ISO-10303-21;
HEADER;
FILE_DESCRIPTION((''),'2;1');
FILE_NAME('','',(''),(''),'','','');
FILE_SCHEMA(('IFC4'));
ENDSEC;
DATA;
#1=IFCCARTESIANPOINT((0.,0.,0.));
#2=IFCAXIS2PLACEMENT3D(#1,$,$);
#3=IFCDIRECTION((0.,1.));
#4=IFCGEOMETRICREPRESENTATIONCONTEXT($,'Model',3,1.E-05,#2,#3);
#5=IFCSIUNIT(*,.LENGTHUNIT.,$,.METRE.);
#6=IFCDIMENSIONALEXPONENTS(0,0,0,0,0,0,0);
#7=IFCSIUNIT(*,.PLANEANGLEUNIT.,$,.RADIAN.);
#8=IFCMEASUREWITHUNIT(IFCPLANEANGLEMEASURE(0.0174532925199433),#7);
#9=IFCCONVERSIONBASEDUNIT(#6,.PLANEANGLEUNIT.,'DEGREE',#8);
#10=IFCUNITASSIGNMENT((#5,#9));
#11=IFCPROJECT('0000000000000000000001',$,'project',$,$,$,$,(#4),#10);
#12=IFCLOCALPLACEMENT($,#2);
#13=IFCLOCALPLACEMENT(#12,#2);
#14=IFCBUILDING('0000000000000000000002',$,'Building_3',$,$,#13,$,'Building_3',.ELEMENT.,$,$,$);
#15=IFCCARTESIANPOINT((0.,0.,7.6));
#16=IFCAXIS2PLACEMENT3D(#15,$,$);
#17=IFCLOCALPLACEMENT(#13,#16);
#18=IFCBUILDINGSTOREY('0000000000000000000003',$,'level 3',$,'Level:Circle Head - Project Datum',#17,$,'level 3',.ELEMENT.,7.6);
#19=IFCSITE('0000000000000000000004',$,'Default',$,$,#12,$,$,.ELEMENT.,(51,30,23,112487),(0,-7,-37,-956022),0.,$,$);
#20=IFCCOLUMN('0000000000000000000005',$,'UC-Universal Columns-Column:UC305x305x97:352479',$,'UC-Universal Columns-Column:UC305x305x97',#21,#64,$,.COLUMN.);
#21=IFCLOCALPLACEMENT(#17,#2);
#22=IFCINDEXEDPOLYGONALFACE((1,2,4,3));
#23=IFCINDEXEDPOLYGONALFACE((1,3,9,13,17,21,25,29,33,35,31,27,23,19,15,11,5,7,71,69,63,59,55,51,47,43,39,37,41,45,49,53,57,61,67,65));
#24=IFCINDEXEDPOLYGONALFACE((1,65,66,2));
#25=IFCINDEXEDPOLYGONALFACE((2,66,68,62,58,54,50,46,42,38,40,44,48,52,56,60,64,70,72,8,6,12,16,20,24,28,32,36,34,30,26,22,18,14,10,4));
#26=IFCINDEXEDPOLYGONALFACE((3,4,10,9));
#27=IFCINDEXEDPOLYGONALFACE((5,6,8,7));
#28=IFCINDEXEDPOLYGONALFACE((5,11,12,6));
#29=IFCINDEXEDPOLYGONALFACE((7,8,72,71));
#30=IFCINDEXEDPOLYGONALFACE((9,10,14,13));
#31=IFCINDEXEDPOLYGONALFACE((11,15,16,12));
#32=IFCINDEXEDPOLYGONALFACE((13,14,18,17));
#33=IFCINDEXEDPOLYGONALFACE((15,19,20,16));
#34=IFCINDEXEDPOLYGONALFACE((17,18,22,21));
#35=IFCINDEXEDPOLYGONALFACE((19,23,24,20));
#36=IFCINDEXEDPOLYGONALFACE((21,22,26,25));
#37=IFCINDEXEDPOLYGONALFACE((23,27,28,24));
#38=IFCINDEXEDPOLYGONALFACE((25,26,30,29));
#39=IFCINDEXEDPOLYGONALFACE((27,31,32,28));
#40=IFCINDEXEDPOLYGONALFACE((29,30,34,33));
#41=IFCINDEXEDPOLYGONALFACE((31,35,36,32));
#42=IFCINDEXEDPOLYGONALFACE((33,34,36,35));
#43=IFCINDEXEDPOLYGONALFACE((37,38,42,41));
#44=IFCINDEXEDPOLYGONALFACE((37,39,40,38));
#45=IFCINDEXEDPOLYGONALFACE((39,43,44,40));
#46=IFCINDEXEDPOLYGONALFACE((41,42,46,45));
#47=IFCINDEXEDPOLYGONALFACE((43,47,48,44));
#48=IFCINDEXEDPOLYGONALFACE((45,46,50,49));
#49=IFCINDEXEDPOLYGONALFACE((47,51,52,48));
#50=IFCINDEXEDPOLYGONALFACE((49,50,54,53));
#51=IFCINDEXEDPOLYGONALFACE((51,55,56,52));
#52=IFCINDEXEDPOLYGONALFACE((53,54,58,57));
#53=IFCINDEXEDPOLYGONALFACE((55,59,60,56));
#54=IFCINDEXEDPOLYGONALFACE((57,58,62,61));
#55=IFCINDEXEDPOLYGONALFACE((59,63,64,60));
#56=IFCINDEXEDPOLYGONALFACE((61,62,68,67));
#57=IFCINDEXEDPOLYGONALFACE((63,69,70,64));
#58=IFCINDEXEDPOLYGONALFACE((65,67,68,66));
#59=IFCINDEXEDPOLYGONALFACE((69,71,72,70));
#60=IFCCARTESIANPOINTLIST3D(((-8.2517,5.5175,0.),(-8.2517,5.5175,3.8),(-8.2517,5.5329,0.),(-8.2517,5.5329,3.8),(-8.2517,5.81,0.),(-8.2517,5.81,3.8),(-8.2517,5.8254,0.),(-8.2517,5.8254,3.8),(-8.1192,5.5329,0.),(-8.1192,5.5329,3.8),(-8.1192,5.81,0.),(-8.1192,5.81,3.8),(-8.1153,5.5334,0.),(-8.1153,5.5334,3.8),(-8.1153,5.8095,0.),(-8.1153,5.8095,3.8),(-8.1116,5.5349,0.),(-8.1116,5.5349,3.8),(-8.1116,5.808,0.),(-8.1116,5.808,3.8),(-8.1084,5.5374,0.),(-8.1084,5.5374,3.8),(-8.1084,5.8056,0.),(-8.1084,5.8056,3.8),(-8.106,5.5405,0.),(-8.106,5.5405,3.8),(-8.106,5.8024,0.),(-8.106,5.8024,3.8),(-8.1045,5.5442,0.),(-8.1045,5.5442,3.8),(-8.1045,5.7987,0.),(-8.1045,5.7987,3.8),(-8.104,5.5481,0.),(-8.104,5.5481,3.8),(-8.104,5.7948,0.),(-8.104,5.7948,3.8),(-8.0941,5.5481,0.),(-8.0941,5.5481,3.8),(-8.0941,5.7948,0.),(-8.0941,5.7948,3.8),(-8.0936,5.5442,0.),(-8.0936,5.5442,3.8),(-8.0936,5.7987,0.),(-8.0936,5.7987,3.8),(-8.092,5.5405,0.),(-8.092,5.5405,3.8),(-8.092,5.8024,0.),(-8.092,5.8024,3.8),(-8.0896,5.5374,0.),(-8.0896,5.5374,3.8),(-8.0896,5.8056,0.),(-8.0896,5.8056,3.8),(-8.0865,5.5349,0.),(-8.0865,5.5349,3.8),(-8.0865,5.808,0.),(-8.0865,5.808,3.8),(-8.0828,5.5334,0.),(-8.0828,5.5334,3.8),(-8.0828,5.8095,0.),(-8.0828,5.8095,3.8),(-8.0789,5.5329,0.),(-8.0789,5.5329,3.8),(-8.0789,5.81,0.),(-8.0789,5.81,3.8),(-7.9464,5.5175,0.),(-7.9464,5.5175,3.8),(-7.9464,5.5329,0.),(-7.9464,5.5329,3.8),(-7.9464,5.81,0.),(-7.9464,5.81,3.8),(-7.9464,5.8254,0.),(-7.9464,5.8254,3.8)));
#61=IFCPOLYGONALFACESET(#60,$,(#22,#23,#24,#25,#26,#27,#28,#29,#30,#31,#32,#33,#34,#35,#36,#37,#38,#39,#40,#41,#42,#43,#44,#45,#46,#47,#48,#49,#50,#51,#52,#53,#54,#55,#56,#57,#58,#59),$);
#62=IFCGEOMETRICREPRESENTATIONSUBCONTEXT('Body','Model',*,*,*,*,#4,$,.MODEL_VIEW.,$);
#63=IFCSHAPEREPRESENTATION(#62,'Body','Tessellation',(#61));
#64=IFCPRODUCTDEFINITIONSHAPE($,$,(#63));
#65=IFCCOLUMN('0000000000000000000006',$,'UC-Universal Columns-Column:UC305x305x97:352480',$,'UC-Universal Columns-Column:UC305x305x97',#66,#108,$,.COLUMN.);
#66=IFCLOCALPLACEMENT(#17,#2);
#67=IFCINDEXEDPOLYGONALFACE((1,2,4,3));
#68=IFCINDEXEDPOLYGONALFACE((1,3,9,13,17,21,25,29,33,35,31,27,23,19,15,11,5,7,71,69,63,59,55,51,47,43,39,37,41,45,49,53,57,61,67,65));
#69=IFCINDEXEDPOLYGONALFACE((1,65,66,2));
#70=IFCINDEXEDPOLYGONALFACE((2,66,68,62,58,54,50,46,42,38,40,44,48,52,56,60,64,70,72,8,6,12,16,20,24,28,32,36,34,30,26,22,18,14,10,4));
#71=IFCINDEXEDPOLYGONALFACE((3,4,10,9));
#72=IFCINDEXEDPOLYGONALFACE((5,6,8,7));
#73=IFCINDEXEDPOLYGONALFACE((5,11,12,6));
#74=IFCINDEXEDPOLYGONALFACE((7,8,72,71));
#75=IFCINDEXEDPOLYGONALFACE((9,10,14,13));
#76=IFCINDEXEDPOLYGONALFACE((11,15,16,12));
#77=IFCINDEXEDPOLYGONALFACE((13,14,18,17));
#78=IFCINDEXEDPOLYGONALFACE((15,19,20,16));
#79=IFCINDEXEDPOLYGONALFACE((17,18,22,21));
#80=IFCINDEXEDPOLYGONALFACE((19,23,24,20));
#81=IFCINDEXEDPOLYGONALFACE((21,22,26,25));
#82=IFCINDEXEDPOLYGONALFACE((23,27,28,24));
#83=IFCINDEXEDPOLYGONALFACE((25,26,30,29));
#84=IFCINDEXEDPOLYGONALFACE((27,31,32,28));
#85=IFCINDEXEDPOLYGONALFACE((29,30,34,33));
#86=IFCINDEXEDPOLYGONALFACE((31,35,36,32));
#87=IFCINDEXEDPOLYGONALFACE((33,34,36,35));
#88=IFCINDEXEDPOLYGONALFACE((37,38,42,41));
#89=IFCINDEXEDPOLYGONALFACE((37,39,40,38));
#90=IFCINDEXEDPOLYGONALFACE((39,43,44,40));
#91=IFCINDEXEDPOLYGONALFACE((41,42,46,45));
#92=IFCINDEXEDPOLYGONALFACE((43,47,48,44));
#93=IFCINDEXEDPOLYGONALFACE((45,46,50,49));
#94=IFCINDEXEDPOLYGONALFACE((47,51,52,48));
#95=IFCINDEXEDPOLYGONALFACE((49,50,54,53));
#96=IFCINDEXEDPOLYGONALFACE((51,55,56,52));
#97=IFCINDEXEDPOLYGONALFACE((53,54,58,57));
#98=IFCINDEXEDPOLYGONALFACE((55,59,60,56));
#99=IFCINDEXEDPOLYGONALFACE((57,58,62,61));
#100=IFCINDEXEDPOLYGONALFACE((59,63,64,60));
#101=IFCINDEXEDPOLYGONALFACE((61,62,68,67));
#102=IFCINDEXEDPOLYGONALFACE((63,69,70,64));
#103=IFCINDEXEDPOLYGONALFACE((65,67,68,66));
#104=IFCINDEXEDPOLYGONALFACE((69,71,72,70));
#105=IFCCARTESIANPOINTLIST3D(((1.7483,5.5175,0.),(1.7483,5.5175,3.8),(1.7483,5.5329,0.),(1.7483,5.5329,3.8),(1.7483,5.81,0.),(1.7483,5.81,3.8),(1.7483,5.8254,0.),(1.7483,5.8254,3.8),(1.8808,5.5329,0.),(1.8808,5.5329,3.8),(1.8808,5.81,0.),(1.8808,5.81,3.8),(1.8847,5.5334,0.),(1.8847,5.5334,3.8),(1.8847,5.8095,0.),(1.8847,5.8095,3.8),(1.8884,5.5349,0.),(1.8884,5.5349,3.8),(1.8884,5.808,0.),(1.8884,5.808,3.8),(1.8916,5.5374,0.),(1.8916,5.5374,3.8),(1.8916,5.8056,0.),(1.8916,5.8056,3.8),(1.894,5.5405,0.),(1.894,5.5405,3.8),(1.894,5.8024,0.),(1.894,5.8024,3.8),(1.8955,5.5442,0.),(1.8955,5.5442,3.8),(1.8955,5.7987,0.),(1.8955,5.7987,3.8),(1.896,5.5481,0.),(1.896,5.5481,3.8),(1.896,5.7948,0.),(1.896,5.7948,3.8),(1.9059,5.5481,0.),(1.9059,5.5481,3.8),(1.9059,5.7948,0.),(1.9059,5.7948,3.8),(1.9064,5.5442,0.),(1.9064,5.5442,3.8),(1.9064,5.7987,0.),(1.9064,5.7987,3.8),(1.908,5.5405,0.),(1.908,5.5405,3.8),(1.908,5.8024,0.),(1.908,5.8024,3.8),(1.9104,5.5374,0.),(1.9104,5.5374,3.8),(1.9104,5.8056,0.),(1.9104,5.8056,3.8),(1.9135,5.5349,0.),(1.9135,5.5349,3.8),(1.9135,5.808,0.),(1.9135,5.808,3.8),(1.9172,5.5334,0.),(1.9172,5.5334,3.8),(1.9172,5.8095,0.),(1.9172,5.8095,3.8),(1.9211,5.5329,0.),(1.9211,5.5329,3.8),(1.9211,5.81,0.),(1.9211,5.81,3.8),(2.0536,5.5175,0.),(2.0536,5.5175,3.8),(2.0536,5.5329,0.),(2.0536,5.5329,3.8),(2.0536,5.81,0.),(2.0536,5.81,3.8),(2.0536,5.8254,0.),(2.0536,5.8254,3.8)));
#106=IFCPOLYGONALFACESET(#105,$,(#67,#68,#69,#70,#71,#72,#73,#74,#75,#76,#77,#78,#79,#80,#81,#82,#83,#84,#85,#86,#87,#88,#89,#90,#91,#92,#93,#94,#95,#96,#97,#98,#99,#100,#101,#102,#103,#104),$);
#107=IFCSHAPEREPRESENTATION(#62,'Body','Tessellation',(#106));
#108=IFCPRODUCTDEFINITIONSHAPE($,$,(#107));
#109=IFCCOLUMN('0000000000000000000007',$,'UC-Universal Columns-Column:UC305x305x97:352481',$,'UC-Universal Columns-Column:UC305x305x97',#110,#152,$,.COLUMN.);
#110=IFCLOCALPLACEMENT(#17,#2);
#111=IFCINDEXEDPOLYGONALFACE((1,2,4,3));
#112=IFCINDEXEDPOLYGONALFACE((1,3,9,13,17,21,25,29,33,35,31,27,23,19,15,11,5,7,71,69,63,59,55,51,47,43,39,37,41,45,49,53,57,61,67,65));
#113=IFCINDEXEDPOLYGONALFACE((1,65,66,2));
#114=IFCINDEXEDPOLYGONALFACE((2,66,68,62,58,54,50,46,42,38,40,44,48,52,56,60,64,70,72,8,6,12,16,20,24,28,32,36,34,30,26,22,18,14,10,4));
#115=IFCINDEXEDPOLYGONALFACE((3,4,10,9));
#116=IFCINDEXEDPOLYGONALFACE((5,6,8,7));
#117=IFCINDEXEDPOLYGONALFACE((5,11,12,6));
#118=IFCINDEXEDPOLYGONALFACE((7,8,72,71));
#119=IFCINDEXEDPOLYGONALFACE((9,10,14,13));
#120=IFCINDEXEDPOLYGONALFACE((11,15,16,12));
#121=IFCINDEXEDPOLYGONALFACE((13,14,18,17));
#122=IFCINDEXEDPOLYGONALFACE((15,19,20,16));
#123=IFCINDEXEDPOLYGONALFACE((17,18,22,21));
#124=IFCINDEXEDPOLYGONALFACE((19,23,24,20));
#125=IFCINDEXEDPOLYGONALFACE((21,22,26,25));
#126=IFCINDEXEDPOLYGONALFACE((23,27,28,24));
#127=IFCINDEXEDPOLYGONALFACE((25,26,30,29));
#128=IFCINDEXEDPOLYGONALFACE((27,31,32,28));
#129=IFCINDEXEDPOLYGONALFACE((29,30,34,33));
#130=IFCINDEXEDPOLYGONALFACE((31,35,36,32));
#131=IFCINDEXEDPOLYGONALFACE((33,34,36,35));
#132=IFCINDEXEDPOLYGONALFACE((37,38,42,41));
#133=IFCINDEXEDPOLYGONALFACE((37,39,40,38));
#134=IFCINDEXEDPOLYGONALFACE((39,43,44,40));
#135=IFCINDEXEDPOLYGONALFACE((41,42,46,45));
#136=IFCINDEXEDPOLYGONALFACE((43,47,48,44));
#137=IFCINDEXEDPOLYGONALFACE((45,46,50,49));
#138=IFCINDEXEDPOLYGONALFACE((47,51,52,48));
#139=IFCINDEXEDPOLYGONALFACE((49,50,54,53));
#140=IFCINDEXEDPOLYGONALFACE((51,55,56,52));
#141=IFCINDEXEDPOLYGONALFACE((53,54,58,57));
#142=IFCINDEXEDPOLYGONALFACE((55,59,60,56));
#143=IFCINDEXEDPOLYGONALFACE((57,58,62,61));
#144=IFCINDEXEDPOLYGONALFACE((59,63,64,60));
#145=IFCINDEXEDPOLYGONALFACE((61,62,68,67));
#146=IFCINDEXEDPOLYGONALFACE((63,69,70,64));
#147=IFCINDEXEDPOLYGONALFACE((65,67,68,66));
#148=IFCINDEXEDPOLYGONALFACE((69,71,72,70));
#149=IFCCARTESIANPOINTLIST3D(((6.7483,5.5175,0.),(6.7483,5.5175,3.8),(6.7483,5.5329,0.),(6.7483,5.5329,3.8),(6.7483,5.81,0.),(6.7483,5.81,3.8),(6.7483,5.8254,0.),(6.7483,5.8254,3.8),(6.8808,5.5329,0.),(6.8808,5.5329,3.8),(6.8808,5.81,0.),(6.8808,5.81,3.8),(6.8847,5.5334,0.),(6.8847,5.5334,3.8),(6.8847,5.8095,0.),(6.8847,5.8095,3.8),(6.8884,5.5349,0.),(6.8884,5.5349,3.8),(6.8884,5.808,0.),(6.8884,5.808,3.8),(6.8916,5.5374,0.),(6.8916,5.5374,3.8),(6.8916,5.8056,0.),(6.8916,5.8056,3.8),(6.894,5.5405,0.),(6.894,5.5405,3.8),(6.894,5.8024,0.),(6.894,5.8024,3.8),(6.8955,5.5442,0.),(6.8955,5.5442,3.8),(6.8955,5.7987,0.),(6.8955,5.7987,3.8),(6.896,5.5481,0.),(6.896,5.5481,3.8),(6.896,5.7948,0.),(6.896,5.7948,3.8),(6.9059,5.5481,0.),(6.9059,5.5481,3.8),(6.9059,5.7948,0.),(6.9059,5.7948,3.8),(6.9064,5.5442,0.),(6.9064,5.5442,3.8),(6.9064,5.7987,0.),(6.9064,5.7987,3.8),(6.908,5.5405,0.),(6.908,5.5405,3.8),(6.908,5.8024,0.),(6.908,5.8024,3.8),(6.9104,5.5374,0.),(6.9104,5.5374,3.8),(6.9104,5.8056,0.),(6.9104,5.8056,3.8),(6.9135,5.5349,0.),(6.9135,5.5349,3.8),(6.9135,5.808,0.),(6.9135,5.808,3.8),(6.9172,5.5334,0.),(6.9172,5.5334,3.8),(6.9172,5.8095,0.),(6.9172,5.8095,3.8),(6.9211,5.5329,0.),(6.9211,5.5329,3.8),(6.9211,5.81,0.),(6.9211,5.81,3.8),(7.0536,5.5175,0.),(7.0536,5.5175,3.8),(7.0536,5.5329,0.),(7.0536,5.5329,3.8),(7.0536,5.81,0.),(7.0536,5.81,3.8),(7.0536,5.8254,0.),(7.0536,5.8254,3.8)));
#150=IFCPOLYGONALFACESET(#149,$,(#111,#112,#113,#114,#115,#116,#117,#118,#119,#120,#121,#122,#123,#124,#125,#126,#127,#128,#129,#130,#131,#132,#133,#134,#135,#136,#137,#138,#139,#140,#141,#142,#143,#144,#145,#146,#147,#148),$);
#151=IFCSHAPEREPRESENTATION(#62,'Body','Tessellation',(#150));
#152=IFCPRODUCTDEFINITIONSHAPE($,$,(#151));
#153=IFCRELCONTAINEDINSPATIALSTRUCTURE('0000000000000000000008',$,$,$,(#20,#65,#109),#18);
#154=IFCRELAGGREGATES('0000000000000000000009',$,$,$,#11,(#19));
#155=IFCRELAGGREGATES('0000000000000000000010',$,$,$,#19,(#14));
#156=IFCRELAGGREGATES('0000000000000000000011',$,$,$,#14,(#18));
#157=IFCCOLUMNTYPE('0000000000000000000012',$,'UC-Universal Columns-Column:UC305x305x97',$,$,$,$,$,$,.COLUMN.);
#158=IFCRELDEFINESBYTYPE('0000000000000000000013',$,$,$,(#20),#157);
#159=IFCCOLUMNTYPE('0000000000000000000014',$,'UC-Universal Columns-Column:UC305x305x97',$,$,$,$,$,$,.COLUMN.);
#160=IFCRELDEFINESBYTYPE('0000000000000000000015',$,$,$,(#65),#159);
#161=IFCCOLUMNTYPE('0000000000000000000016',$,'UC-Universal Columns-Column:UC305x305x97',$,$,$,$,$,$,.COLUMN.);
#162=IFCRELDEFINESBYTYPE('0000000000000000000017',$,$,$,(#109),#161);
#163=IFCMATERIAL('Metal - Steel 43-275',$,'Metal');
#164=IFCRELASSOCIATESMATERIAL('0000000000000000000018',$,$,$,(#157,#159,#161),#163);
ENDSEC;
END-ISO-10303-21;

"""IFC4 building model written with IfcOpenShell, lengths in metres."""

from ifc_helpers import new_model, entity, si_unit, converted_unit, direction, frame, frame_2d, origin, place, context, subcontext, project, spatial, i_section, extrude, source, transform, mapped, material, material_profile, profile_set, type_object, type_shapes, element, save


model = new_model("IFC4")

# Units and contexts
model_context = context("Model", 3, precision=1e-05, world=origin(), true_north=direction((0.0, 1.0)))
body_context = subcontext(model_context, "Body", "Model", "MODEL_VIEW")
ifc_project = project(units=[si_unit("LENGTHUNIT", "METRE"), converted_unit("PLANEANGLEUNIT", "DEGREE", entity("IfcPlaneAngleMeasure", 0.0174532925199433), si_unit("PLANEANGLEUNIT", "RADIAN"), dimensions=[0, 0, 0, 0, 0, 0, 0])], contexts=[model_context])

# Site, building, storey
site_placement = place(None, origin())
site = spatial("IfcSite", under=ifc_project, at=site_placement, Name="Default", CompositionType="ELEMENT", RefLatitude=(51, 30, 23, 112487), RefLongitude=(0, -7, -37, -956022), RefElevation=0.0)
building_placement = place(site_placement, origin())
building = spatial("IfcBuilding", under=site, at=building_placement, Name="Building_3", LongName="Building_3", CompositionType="ELEMENT")
storey_placement = place(building_placement, frame((0.0, 0.0, 7.6)))
storey = spatial("IfcBuildingStorey", under=building, at=storey_placement, Name="level 3", ObjectType="Level:Circle Head - Project Datum", LongName="level 3", CompositionType="ELEMENT", Elevation=7.6)

# Columns
ifc_material_1 = material(Name="Metal - Steel 43-275", Category="Metal")
ifc_material_profile_1 = material_profile(ifc_material_1, i_section(OverallWidth=0.3053, OverallDepth=0.3079, WebThickness=0.0099, FlangeThickness=0.0154, FilletRadius=0.0152, at=frame_2d((0.0, 0.0), x_axis=(1.0, 0.0))), Name="UC305x305x97")
ifc_profile_set_1 = profile_set([ifc_material_profile_1], Name="UC305x305x97")
column_type_1 = type_object("IfcColumnType", Name="UC-Universal Columns-Column:UC305x305x97", PredefinedType="COLUMN", material=ifc_profile_set_1)
shared_shape_1 = source(origin(), body_context, "Body", "SweptSolid", [
    extrude(i_section(OverallWidth=0.3053, OverallDepth=0.3079, WebThickness=0.0099, FlangeThickness=0.0154, FilletRadius=0.0152, at=frame_2d((0.0, 0.0), x_axis=(1.0, 0.0))), frame((-8.099, 5.6715, 7.6), z_axis=(0.0, 0.0, 1.0), x_axis=(-1.0, 0.0, 0.0)), (0.0, 0.0, 1.0), 3.8),
])
type_shapes(column_type_1, [shared_shape_1])
column_1_placement = place(storey_placement, frame((0.0, 0.0, -7.6)))
element("IfcColumn", 1, at=column_1_placement, inside=storey, type_object=column_type_1, Name="UC-Universal Columns-Column:UC305x305x97:352479", ObjectType="UC-Universal Columns-Column:UC305x305x97", PredefinedType="COLUMN", context=body_context, shape_type="MappedRepresentation", body=[
    mapped(shared_shape_1, transform((0.0, 0.0, 0.0), scale=1.0)),
])
column_type_2 = type_object("IfcColumnType", Name="UC-Universal Columns-Column:UC305x305x97", PredefinedType="COLUMN", material=ifc_profile_set_1)
shared_shape_2 = source(origin(), body_context, "Body", "SweptSolid", [
    extrude(i_section(OverallWidth=0.3053, OverallDepth=0.3079, WebThickness=0.0099, FlangeThickness=0.0154, FilletRadius=0.0152, at=frame_2d((0.0, 0.0), x_axis=(1.0, 0.0))), frame((1.901, 5.6715, 7.6), z_axis=(0.0, 0.0, 1.0), x_axis=(-1.0, 0.0, 0.0)), (0.0, 0.0, 1.0), 3.8),
])
type_shapes(column_type_2, [shared_shape_2])
column_2_placement = place(storey_placement, frame((0.0, 0.0, -7.6)))
element("IfcColumn", 2, at=column_2_placement, inside=storey, type_object=column_type_2, Name="UC-Universal Columns-Column:UC305x305x97:352480", ObjectType="UC-Universal Columns-Column:UC305x305x97", PredefinedType="COLUMN", context=body_context, shape_type="MappedRepresentation", body=[
    mapped(shared_shape_2, transform((0.0, 0.0, 0.0), scale=1.0)),
])
column_type_3 = type_object("IfcColumnType", Name="UC-Universal Columns-Column:UC305x305x97", PredefinedType="COLUMN", material=ifc_profile_set_1)
shared_shape_3 = source(origin(), body_context, "Body", "SweptSolid", [
    extrude(i_section(OverallWidth=0.3053, OverallDepth=0.3079, WebThickness=0.0099, FlangeThickness=0.0154, FilletRadius=0.0152, at=frame_2d((0.0, 0.0), x_axis=(1.0, 0.0))), frame((6.901, 5.6715, 7.6), z_axis=(0.0, 0.0, 1.0), x_axis=(-1.0, 0.0, 0.0)), (0.0, 0.0, 1.0), 3.8),
])
type_shapes(column_type_3, [shared_shape_3])
column_3_placement = place(storey_placement, frame((0.0, 0.0, -7.6)))
element("IfcColumn", 3, at=column_3_placement, inside=storey, type_object=column_type_3, Name="UC-Universal Columns-Column:UC305x305x97:352481", ObjectType="UC-Universal Columns-Column:UC305x305x97", PredefinedType="COLUMN", context=body_context, shape_type="MappedRepresentation", body=[
    mapped(shared_shape_3, transform((0.0, 0.0, 0.0), scale=1.0)),
])

save(model, "model.ifc")
